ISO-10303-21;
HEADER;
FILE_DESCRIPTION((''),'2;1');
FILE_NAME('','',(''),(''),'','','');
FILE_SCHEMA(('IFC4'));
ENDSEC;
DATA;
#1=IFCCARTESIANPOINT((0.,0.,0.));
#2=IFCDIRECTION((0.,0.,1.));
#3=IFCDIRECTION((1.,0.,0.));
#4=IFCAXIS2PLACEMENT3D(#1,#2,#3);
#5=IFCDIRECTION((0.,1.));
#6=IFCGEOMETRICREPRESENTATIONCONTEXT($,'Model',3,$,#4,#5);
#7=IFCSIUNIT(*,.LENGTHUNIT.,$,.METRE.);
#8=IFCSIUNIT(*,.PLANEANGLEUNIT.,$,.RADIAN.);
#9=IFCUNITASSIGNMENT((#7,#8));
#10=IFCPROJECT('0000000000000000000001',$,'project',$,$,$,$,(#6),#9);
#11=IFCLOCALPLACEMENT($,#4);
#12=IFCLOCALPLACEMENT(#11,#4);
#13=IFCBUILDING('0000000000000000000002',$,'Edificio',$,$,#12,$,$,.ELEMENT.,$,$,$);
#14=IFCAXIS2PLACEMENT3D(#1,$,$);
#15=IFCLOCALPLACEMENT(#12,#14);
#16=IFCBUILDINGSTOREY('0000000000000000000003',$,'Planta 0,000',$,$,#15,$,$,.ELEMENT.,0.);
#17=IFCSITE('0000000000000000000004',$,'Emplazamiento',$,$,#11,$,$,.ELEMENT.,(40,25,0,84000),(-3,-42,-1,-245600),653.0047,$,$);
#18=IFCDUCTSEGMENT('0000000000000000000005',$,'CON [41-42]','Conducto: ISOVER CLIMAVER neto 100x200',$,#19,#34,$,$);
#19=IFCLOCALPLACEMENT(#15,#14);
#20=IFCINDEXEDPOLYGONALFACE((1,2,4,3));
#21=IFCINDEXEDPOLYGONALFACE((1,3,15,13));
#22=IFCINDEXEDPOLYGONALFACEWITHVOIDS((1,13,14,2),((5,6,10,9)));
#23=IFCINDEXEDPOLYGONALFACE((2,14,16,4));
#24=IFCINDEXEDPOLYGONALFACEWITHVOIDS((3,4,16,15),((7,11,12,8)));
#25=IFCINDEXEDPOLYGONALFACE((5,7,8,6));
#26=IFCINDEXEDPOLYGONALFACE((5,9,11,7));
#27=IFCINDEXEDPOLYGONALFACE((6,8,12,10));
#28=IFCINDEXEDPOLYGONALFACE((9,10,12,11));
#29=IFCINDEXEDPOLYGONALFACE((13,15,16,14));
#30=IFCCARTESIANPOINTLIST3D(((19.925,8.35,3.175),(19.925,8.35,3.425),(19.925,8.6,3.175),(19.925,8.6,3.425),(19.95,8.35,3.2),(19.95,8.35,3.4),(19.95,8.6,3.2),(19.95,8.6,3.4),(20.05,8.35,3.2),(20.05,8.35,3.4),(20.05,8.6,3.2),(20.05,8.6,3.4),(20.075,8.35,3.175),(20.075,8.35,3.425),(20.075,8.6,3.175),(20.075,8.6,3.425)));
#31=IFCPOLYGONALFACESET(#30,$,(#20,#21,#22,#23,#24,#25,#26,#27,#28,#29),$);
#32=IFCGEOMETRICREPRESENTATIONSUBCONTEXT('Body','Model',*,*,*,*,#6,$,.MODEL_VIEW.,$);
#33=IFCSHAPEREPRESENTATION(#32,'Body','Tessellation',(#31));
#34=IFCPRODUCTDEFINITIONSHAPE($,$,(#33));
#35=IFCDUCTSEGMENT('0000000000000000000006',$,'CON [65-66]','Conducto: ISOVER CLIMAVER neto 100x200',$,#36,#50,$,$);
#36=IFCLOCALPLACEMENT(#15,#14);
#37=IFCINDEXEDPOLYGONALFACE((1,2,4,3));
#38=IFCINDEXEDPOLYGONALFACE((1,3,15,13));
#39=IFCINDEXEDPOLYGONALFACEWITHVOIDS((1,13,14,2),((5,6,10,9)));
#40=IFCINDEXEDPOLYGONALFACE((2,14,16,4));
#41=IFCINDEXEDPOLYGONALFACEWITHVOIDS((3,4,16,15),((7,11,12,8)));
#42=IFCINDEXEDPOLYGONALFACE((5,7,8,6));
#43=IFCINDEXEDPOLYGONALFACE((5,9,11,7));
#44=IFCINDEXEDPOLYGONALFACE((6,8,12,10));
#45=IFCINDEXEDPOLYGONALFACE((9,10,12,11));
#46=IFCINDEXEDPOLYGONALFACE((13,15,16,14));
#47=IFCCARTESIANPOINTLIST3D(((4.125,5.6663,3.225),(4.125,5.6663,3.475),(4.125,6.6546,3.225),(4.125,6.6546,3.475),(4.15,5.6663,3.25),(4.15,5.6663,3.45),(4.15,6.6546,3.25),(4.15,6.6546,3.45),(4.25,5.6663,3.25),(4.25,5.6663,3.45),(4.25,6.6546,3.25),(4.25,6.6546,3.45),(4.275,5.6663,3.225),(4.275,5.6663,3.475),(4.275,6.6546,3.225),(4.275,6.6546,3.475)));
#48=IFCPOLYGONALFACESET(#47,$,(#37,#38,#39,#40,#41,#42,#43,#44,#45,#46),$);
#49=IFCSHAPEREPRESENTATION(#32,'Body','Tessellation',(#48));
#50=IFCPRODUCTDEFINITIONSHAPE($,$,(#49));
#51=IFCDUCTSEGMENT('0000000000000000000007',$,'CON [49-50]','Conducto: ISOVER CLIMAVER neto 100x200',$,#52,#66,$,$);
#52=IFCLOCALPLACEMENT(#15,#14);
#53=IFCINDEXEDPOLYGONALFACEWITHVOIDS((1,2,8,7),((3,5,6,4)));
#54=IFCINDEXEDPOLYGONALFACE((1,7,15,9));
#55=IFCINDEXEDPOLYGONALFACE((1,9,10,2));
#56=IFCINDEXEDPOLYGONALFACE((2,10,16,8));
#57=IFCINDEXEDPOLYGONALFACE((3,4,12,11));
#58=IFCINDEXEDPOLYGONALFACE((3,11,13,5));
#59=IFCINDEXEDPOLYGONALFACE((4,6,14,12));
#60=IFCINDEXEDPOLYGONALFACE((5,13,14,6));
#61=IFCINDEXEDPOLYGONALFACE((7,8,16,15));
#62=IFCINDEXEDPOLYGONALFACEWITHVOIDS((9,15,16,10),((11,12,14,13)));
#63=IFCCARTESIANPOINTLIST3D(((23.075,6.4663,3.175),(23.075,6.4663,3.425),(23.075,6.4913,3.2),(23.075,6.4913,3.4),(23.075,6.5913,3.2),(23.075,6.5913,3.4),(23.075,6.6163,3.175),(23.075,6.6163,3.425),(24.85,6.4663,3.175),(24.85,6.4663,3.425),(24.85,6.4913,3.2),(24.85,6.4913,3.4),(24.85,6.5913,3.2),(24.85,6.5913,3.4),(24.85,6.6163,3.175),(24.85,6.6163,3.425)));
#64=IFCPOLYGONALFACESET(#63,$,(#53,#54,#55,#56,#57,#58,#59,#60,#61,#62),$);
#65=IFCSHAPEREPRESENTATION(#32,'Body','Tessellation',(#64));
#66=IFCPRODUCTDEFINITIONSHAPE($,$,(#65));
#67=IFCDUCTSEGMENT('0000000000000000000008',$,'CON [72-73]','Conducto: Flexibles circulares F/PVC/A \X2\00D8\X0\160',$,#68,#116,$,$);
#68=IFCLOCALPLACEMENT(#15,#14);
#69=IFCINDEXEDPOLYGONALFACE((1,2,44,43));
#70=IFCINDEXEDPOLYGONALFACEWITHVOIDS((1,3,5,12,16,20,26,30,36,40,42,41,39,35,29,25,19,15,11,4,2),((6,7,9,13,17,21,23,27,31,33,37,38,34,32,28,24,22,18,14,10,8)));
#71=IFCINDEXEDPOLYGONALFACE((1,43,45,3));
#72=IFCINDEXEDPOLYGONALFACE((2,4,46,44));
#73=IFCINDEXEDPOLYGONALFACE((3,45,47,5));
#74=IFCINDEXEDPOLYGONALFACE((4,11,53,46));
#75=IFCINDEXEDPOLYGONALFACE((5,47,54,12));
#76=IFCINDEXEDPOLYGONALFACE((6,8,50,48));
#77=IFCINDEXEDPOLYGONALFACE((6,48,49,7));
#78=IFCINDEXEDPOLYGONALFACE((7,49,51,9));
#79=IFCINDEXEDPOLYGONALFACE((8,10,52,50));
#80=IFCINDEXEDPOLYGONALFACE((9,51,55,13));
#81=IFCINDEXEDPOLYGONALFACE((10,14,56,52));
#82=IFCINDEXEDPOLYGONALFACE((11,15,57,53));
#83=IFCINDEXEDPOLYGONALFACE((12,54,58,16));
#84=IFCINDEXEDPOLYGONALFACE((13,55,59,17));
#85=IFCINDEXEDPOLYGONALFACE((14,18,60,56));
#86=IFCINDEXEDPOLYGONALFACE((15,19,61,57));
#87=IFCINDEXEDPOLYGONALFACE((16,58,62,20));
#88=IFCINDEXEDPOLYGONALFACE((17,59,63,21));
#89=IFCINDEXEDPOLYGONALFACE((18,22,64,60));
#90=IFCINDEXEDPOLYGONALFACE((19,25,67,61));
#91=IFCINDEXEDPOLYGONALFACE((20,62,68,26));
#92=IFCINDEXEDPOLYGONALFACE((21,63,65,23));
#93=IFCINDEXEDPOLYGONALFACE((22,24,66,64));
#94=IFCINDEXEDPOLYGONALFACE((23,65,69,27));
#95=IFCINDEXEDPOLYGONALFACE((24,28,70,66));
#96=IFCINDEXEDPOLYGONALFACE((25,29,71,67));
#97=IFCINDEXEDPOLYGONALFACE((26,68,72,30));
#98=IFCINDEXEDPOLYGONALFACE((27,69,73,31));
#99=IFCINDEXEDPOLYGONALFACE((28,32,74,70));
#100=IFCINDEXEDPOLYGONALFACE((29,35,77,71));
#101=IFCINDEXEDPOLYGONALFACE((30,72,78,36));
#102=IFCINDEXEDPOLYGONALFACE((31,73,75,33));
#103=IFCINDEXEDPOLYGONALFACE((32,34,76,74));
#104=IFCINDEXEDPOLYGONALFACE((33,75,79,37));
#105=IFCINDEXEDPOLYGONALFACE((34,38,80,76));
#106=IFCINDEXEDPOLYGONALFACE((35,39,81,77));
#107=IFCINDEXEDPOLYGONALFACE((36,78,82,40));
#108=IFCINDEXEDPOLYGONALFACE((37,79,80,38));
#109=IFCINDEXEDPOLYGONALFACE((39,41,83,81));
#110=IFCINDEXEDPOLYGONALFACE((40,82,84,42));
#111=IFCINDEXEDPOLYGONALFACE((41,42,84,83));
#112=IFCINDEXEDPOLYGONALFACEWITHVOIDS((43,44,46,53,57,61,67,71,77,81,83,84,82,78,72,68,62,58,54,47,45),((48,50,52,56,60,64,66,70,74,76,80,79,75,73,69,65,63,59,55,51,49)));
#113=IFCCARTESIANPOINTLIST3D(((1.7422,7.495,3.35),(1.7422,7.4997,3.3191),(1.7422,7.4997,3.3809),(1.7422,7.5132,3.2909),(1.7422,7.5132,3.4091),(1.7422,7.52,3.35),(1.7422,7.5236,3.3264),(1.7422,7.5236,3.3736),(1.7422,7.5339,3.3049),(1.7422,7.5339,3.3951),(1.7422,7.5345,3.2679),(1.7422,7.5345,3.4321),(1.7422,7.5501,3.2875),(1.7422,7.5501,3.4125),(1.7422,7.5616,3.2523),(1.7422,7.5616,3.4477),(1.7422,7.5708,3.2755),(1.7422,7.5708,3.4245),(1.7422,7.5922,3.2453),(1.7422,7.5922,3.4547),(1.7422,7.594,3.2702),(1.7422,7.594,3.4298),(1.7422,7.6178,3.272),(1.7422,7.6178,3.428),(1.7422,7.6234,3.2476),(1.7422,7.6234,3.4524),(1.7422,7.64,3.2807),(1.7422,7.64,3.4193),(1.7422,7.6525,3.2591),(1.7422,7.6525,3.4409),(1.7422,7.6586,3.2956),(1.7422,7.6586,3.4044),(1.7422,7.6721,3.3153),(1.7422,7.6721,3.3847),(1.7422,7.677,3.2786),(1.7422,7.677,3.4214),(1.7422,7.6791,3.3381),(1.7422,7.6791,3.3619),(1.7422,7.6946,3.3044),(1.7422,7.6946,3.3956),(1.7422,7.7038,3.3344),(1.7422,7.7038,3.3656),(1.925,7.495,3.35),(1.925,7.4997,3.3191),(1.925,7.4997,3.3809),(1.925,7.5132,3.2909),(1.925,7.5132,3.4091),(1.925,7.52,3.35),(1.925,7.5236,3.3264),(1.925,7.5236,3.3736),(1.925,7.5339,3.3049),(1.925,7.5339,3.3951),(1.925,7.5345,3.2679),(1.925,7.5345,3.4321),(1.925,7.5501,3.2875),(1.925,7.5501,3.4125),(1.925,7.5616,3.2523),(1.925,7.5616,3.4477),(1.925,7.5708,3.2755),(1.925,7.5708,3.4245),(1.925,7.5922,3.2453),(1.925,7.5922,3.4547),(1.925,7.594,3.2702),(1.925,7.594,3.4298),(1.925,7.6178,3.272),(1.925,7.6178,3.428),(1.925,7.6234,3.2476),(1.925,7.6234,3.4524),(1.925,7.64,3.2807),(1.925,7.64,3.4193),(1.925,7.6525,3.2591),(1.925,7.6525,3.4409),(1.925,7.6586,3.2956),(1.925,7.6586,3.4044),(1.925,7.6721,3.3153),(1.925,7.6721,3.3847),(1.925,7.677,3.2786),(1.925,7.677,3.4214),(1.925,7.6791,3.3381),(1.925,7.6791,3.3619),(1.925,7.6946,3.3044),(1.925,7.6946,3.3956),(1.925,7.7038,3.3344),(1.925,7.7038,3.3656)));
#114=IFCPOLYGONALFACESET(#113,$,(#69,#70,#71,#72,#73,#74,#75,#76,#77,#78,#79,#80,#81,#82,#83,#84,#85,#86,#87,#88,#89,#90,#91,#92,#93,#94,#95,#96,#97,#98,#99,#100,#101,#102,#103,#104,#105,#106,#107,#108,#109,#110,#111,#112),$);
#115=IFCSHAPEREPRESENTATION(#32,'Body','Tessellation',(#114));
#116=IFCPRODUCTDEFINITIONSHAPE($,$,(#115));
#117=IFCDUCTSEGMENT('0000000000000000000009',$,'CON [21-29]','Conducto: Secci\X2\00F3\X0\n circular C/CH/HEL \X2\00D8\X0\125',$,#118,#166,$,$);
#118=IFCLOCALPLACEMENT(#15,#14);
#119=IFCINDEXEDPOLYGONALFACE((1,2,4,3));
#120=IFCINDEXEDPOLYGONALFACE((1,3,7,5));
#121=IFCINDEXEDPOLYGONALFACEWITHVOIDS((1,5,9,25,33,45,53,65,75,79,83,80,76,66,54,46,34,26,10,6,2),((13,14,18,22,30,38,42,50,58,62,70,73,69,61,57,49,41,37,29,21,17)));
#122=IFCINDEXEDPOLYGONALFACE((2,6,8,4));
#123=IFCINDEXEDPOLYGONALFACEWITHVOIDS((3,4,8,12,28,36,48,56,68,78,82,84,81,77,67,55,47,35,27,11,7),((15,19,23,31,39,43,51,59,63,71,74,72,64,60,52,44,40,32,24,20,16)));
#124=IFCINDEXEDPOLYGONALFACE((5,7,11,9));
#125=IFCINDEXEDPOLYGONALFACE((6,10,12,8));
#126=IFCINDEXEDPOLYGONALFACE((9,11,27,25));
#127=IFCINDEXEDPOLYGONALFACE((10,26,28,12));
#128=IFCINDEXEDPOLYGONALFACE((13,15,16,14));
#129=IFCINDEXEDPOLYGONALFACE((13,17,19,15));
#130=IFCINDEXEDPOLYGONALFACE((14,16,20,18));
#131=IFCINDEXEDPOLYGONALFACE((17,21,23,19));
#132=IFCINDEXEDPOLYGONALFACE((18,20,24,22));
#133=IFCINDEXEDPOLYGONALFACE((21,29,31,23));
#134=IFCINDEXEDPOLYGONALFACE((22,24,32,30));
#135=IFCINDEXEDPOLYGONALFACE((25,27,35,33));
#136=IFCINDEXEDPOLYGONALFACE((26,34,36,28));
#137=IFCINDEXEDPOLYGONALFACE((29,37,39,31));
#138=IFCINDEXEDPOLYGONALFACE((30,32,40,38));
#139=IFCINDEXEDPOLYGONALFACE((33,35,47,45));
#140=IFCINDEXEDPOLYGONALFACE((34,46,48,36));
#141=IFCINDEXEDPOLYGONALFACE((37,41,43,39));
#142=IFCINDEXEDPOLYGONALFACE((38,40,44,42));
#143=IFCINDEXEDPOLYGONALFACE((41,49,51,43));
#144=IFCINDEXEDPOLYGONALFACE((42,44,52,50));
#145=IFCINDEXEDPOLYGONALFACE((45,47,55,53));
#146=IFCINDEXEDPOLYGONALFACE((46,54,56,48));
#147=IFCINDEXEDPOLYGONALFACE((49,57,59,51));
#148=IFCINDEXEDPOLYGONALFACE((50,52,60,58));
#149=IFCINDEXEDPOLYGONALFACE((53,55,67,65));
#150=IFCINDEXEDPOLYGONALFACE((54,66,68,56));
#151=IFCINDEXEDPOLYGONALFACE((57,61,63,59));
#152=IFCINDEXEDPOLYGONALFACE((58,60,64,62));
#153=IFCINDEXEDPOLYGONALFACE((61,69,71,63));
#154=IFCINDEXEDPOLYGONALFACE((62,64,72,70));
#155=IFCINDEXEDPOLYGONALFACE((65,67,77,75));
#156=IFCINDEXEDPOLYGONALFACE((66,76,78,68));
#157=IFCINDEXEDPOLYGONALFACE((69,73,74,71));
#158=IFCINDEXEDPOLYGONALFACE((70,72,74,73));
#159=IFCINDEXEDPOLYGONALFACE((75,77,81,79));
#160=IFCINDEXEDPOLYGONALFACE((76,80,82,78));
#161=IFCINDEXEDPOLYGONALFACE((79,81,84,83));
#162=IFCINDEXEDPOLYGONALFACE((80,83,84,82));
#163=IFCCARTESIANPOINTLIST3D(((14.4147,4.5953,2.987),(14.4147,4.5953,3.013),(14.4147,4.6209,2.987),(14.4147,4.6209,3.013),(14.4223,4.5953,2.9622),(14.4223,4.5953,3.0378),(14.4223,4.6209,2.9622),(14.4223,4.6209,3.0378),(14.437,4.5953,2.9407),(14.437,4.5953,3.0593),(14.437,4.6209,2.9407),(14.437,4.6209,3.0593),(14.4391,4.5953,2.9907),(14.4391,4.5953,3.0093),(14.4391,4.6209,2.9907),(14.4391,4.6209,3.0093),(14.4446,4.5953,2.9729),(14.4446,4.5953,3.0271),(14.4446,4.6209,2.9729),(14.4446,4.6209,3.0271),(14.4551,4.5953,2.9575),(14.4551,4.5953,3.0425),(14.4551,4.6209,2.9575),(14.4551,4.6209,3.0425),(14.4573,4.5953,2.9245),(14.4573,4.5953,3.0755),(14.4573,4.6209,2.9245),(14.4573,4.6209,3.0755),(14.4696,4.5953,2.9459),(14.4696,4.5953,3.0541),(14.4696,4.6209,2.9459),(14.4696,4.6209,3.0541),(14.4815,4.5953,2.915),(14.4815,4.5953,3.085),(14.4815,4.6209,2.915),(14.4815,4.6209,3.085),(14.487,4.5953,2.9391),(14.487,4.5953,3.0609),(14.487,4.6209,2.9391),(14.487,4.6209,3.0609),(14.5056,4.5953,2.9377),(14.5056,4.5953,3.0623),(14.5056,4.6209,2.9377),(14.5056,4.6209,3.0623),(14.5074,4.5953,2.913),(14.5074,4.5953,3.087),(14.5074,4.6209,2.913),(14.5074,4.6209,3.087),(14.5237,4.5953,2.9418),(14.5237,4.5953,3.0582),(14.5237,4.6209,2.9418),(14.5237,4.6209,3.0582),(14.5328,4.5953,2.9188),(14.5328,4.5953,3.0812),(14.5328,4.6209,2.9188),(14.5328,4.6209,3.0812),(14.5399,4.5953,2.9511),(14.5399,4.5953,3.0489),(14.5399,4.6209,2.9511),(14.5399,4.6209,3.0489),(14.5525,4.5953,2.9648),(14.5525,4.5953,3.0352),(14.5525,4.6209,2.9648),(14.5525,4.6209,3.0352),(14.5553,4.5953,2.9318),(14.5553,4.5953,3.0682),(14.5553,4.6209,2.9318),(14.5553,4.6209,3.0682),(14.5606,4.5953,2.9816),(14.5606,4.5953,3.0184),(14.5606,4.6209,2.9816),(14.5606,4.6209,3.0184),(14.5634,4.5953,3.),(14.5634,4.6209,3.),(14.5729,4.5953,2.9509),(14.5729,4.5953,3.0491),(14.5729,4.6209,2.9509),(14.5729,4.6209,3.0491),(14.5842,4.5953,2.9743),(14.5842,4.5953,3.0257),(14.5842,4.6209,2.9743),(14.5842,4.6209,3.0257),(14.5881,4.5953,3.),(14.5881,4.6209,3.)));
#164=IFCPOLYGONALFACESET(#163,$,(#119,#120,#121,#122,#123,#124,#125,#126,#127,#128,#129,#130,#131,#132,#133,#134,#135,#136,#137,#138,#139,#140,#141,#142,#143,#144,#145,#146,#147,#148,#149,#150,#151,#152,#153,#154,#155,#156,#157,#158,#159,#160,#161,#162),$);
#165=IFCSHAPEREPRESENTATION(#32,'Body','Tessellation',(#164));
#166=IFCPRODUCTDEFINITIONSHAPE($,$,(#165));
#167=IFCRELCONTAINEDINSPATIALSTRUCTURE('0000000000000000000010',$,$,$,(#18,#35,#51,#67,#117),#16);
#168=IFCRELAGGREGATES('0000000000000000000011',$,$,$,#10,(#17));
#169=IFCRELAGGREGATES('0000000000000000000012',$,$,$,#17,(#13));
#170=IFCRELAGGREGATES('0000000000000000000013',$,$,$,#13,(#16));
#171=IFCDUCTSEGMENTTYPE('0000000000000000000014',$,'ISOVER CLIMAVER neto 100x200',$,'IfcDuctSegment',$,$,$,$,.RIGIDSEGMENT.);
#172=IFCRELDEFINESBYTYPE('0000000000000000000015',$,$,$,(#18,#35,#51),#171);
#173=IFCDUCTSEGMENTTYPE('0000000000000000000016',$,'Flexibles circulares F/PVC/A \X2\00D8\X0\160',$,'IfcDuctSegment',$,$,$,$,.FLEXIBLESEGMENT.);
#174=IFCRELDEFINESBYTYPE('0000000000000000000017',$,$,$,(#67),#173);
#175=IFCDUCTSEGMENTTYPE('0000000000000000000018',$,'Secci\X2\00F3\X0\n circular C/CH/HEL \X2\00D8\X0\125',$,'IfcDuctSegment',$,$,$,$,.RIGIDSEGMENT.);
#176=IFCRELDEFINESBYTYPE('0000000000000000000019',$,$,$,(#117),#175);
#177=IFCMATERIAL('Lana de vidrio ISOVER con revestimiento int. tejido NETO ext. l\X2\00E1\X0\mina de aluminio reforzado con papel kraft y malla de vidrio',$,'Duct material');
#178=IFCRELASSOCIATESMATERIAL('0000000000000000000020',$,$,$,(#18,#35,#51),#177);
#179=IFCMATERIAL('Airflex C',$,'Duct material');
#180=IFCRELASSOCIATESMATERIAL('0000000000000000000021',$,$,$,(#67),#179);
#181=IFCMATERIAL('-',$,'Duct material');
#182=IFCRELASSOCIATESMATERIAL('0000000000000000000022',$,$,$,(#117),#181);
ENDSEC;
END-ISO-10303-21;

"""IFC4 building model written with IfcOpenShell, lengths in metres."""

from ifc_helpers import new_model, si_unit, direction, frame, origin, origin_with_axes, origin_2d_with_axis, place, context, subcontext, project, spatial, hollow_rectangle, hollow_circle, extrude, material, type_object, element, save


model = new_model("IFC4")

# Units and contexts
model_context = context("Model", 3, world=origin_with_axes(), true_north=direction((0.0, 1.0)))
body_context = subcontext(model_context, "Body", "Model", "MODEL_VIEW")
ifc_project = project(units=[si_unit("LENGTHUNIT", "METRE"), si_unit("PLANEANGLEUNIT", "RADIAN")], contexts=[model_context])

# Site, building, storey
site_placement = place(None, origin_with_axes())
site = spatial("IfcSite", under=ifc_project, at=site_placement, Name="Emplazamiento", CompositionType="ELEMENT", RefLatitude=(40, 25, 0, 84000), RefLongitude=(-3, -42, -1, -245600), RefElevation=653.0047)
building_placement = place(site_placement, origin_with_axes())
building = spatial("IfcBuilding", under=site, at=building_placement, Name="Edificio", CompositionType="ELEMENT")
storey_placement = place(building_placement, origin())
storey = spatial("IfcBuildingStorey", under=building, at=storey_placement, Name="Planta 0,000", CompositionType="ELEMENT", Elevation=0.0)

# Duct segments
ifc_material_1 = material(Name="Lana de vidrio ISOVER con revestimiento int. tejido NETO ext. lámina de aluminio reforzado con papel kraft y malla de vidrio", Category="Duct material")
duct_segment_type_1 = type_object("IfcDuctSegmentType", Name="ISOVER CLIMAVER neto 100x200", ApplicableOccurrence="IfcDuctSegment", PredefinedType="RIGIDSEGMENT")
duct_segment_1_placement = place(storey_placement, origin_with_axes())
element("IfcDuctSegment", 1, at=duct_segment_1_placement, inside=storey, type_object=duct_segment_type_1, material=ifc_material_1, Name="CON [41-42]", Description="Conducto: ISOVER CLIMAVER neto 100x200", context=body_context, shape_type="SweptSolid", body=[
    extrude(hollow_rectangle(XDim=0.15, YDim=0.25, WallThickness=0.025, at=origin_2d_with_axis()), frame((20.0, 8.35, 3.3), z_axis=(0.0, 1.0, 0.0), x_axis=(-1.0, 0.0, 0.0)), (0.0, 0.0, 1.0), 0.25),
])
duct_segment_2_placement = place(storey_placement, origin_with_axes())
element("IfcDuctSegment", 2, at=duct_segment_2_placement, inside=storey, type_object=duct_segment_type_1, material=ifc_material_1, Name="CON [65-66]", Description="Conducto: ISOVER CLIMAVER neto 100x200", context=body_context, shape_type="SweptSolid", body=[
    extrude(hollow_rectangle(XDim=0.15, YDim=0.25, WallThickness=0.025, at=origin_2d_with_axis()), frame((4.2, 6.6546, 3.35), z_axis=(0.0, -1.0, 0.0), x_axis=(1.0, 0.0, 0.0)), (0.0, 0.0, 1.0), 0.9884),
])
duct_segment_3_placement = place(storey_placement, origin_with_axes())
element("IfcDuctSegment", 3, at=duct_segment_3_placement, inside=storey, type_object=duct_segment_type_1, material=ifc_material_1, Name="CON [49-50]", Description="Conducto: ISOVER CLIMAVER neto 100x200", context=body_context, shape_type="SweptSolid", body=[
    extrude(hollow_rectangle(XDim=0.15, YDim=0.25, WallThickness=0.025, at=origin_2d_with_axis()), frame((23.075, 6.5413, 3.3), z_axis=(1.0, 0.0, 0.0), x_axis=(0.0, 1.0, 0.0)), (0.0, 0.0, 1.0), 1.775),
])
ifc_material_2 = material(Name="Airflex C", Category="Duct material")
duct_segment_type_2 = type_object("IfcDuctSegmentType", Name="Flexibles circulares F/PVC/A Ø160", ApplicableOccurrence="IfcDuctSegment", PredefinedType="FLEXIBLESEGMENT")
duct_segment_4_placement = place(storey_placement, origin_with_axes())
element("IfcDuctSegment", 4, at=duct_segment_4_placement, inside=storey, type_object=duct_segment_type_2, material=ifc_material_2, Name="CON [72-73]", Description="Conducto: Flexibles circulares F/PVC/A Ø160", context=body_context, shape_type="SweptSolid", body=[
    extrude(hollow_circle(Radius=0.105, WallThickness=0.025, at=origin_2d_with_axis()), frame((1.925, 7.6, 3.35), z_axis=(-1.0, 0.0, 0.0), x_axis=(0.0, -1.0, 0.0)), (0.0, 0.0, 1.0), 0.1828),
])
ifc_material_3 = material(Name="-", Category="Duct material")
duct_segment_type_3 = type_object("IfcDuctSegmentType", Name="Sección circular C/CH/HEL Ø125", ApplicableOccurrence="IfcDuctSegment", PredefinedType="RIGIDSEGMENT")
duct_segment_5_placement = place(storey_placement, origin_with_axes())
element("IfcDuctSegment", 5, at=duct_segment_5_placement, inside=storey, type_object=duct_segment_type_3, material=ifc_material_3, Name="CON [21-29]", Description="Conducto: Sección circular C/CH/HEL Ø125", context=body_context, shape_type="SweptSolid", body=[
    extrude(hollow_circle(Radius=0.0872, WallThickness=0.0247, at=origin_2d_with_axis()), frame((14.5009, 4.6209, 3.0), z_axis=(0.0, -1.0, 0.0), x_axis=(1.0, 0.0, 0.0)), (0.0, 0.0, 1.0), 0.0256),
])

save(model, "model.ifc")
